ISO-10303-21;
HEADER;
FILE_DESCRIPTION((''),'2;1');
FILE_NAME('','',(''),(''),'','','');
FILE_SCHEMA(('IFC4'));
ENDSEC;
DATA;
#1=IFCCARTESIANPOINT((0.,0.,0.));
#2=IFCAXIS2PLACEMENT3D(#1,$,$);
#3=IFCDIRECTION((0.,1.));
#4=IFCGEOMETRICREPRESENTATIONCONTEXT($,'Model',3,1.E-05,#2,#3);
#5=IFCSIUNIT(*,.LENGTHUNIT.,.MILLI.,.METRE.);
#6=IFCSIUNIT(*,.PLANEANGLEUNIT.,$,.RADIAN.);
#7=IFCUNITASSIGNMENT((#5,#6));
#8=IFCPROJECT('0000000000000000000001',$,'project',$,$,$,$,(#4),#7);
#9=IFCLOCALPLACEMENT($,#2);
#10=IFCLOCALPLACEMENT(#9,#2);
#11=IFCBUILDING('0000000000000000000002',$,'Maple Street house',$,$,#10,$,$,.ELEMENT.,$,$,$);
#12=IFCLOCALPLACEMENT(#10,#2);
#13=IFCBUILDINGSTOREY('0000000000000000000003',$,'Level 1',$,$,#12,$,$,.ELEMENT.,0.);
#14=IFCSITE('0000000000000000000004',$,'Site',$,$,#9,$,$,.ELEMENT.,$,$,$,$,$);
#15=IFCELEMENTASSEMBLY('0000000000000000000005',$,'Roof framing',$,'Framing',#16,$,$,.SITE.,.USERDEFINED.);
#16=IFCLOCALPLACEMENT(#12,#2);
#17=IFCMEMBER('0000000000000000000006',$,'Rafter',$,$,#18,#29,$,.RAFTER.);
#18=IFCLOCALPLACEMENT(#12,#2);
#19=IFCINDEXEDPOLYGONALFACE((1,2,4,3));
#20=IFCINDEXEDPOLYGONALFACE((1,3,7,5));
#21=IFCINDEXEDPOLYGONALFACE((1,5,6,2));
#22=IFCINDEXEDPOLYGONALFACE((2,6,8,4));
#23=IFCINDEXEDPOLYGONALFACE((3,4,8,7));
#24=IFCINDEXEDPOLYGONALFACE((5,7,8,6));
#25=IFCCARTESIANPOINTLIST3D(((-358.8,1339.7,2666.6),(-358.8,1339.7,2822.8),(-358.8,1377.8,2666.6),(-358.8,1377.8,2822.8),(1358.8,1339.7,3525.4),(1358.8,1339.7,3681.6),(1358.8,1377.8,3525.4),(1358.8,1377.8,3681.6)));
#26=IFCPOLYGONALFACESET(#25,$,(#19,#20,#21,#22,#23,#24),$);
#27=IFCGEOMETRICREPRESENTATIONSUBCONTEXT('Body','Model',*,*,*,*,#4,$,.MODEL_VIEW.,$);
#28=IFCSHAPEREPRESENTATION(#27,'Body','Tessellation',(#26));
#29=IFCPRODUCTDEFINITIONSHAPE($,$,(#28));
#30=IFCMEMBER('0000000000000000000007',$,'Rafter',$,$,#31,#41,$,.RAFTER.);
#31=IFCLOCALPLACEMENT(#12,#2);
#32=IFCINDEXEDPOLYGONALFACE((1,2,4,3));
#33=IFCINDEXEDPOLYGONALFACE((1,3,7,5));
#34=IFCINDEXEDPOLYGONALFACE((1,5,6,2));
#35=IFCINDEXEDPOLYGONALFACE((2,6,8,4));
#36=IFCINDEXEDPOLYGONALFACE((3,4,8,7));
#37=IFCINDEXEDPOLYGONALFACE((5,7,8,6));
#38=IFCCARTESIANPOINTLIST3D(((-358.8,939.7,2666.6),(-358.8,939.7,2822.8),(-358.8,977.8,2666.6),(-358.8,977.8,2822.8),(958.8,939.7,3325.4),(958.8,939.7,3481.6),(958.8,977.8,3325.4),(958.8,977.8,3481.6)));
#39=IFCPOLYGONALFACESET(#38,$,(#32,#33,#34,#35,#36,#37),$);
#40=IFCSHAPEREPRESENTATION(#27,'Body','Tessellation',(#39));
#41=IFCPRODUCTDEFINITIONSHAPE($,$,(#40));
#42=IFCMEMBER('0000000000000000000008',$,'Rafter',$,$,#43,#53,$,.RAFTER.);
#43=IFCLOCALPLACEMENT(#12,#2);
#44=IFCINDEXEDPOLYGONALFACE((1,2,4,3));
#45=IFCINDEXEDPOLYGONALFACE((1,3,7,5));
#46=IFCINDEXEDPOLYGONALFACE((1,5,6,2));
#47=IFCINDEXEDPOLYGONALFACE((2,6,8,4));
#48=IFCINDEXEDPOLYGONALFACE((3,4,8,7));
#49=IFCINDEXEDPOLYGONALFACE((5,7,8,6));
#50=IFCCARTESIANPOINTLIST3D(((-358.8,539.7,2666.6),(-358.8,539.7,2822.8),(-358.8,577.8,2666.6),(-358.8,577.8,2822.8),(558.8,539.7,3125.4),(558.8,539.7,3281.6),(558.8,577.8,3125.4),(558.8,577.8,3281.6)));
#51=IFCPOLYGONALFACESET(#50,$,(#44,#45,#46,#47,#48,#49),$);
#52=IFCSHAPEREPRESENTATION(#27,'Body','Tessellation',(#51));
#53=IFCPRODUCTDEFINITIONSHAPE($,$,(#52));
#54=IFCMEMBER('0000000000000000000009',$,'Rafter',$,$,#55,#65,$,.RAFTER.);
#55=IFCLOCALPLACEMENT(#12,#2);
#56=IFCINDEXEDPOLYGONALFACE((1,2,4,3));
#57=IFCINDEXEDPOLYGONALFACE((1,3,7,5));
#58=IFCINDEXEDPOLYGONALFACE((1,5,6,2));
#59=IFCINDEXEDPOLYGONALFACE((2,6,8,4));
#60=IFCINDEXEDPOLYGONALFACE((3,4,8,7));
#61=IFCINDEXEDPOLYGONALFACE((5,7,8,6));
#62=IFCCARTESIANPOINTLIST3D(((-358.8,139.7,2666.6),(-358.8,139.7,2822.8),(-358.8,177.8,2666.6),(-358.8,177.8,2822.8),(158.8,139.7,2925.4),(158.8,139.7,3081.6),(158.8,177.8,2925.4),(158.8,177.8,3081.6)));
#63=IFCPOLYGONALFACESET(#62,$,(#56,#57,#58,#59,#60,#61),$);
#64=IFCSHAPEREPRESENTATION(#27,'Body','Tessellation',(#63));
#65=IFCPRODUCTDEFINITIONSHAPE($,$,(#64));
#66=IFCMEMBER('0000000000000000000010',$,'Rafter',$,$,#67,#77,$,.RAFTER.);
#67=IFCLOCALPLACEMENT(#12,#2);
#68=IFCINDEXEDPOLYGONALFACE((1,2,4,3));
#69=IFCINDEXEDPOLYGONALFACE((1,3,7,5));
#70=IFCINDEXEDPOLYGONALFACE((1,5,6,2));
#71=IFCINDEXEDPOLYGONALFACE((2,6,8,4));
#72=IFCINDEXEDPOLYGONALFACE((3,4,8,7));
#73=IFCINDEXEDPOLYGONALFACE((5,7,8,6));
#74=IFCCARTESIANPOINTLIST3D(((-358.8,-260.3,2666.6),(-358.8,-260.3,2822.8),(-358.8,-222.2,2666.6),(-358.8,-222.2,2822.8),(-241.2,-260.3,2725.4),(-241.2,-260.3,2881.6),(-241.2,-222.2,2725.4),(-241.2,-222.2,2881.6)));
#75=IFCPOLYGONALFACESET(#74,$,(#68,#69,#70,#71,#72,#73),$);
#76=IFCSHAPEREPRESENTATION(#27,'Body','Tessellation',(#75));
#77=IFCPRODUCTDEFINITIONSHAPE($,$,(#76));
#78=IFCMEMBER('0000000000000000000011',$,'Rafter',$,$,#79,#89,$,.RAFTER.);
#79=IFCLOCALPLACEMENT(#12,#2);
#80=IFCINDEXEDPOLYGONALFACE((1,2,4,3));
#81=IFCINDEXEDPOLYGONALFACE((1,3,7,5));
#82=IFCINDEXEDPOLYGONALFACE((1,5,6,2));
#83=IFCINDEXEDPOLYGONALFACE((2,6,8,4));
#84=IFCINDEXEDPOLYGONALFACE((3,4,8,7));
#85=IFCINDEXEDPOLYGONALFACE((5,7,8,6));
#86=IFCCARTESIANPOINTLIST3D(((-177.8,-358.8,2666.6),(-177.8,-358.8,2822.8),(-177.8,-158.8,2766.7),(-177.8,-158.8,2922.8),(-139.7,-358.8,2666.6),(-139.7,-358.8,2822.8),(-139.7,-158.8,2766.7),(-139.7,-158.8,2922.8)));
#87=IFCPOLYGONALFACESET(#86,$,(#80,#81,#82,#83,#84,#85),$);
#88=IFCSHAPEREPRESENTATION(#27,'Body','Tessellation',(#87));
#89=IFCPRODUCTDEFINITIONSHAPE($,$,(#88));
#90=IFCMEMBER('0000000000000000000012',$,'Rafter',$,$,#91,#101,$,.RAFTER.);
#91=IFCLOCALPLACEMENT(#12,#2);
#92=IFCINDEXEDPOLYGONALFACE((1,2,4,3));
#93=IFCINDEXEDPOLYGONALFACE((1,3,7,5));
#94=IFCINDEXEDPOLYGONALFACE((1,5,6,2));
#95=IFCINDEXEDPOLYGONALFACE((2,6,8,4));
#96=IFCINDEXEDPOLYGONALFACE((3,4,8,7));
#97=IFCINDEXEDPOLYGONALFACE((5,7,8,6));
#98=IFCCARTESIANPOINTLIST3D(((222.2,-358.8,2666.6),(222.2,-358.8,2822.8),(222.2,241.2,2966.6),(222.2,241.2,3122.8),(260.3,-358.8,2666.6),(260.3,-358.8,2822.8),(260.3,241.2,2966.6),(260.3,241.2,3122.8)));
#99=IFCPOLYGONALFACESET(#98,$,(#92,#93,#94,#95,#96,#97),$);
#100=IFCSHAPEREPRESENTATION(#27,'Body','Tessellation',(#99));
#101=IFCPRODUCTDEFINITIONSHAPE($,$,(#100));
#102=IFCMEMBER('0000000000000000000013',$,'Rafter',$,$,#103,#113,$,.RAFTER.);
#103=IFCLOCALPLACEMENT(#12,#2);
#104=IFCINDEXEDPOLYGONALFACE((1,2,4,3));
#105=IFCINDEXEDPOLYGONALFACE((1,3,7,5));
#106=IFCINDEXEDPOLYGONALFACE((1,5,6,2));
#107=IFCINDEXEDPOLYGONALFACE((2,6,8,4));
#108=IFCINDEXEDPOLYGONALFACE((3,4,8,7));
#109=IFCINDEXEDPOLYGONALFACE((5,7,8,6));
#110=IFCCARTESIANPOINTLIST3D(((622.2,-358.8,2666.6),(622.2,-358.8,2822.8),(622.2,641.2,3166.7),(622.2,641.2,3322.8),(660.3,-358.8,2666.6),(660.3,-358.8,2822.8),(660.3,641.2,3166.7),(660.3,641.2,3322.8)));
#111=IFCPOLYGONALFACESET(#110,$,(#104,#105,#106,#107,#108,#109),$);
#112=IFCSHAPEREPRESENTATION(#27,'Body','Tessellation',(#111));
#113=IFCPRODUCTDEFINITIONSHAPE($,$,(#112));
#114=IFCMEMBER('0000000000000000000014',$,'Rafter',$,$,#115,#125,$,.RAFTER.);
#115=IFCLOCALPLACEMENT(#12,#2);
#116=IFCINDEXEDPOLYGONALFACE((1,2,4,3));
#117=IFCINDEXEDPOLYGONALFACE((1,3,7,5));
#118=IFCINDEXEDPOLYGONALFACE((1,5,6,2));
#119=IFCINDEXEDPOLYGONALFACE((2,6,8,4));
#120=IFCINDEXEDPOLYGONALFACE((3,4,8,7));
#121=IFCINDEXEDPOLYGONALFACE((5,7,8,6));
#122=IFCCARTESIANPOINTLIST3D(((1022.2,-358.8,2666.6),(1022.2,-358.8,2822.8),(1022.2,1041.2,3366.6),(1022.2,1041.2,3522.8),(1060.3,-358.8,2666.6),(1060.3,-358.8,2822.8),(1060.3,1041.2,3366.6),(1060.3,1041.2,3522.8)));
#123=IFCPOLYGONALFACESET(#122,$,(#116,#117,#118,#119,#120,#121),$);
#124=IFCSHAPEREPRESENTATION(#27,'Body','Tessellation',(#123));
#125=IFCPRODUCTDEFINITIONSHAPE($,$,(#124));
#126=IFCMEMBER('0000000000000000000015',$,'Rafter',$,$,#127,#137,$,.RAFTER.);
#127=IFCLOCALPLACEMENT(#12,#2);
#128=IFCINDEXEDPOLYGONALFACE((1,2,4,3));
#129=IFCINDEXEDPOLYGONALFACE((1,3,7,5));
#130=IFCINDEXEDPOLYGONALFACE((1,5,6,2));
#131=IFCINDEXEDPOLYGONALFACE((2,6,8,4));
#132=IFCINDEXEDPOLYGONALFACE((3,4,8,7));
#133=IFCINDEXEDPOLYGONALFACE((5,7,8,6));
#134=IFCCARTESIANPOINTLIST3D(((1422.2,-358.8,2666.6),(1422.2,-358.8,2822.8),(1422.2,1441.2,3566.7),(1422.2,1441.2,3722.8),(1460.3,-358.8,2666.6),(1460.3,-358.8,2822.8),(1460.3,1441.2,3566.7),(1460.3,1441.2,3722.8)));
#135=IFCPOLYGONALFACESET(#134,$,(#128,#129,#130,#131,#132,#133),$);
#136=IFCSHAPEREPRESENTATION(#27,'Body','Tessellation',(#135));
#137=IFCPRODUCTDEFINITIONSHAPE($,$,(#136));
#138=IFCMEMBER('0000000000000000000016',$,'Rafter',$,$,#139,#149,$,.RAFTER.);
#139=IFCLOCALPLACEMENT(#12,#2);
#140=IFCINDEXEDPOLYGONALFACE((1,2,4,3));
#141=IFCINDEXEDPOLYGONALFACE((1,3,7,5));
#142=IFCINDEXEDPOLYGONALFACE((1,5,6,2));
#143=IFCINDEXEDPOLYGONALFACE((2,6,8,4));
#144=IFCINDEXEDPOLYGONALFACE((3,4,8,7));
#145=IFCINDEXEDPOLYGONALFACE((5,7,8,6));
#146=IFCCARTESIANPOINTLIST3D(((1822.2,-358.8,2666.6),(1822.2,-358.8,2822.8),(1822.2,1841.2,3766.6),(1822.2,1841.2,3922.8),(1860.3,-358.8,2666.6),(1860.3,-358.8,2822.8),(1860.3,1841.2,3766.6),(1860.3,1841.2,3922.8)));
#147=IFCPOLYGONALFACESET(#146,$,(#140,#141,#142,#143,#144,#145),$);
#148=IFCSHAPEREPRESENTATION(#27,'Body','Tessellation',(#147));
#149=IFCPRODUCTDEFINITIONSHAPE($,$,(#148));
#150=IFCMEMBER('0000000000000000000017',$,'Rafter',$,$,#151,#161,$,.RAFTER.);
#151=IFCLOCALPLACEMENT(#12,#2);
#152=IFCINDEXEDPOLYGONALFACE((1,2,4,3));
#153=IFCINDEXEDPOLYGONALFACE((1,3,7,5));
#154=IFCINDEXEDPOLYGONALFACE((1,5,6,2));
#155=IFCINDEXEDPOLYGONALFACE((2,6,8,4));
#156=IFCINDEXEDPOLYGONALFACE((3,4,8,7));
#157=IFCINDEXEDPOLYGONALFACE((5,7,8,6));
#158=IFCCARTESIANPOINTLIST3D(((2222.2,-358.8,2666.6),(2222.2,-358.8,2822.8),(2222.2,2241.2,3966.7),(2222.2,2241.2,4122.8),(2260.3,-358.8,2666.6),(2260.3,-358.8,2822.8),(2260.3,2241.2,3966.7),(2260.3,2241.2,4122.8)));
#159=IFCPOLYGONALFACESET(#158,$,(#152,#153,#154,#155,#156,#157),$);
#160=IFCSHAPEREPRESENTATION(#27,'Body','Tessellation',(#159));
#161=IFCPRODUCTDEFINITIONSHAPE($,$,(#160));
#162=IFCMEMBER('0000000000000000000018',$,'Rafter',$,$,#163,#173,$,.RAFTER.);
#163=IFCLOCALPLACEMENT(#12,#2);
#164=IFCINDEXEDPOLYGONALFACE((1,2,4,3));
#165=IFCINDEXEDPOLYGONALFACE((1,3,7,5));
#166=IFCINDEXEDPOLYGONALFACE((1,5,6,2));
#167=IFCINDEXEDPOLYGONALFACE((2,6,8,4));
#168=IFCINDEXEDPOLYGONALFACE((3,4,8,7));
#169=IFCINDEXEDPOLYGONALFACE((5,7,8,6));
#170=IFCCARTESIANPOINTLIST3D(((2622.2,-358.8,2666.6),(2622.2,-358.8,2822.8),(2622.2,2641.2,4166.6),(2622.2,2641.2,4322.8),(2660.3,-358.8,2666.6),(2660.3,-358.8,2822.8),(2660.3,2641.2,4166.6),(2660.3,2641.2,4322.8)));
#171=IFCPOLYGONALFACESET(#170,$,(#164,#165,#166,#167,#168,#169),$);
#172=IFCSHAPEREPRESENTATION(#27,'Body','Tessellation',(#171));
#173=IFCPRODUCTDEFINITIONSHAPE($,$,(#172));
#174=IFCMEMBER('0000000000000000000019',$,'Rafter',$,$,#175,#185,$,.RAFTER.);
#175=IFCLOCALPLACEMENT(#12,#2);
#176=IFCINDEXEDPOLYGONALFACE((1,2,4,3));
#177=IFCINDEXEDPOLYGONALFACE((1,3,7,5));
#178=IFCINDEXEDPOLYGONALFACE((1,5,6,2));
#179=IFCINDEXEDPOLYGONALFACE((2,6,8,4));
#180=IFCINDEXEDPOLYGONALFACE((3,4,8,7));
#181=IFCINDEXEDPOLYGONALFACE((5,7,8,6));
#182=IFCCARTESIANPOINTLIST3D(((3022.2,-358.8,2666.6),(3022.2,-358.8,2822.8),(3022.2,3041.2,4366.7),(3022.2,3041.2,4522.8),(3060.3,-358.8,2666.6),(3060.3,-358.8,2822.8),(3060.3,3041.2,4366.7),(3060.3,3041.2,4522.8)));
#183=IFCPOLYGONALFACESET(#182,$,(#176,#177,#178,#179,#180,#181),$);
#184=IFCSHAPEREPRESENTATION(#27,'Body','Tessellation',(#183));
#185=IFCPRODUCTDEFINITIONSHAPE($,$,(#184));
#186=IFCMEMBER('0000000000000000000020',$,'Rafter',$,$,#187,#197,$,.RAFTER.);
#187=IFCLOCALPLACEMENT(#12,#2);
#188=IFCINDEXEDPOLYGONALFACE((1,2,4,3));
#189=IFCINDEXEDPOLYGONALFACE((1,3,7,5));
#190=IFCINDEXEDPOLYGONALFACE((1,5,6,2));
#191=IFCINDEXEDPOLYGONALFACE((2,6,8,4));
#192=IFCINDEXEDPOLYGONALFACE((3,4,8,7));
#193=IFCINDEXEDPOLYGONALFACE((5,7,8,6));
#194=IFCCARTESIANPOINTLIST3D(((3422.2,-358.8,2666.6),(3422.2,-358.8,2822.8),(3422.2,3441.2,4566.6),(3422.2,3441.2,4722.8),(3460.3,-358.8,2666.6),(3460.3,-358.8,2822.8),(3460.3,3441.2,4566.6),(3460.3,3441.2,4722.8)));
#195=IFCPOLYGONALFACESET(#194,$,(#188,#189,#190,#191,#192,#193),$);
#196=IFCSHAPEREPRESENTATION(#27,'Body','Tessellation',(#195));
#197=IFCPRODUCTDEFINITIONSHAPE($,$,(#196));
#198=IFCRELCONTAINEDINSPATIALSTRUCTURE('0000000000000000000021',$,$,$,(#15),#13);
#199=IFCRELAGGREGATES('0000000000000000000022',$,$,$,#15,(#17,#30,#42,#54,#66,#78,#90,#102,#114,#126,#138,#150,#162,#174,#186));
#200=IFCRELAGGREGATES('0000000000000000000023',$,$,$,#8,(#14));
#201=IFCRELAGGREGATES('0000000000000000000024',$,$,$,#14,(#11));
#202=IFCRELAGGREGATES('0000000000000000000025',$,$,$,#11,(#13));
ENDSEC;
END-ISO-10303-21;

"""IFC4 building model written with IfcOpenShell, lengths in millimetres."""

from ifc_helpers import new_model, si_unit, direction, frame, origin, origin_with_axes, place, context, subcontext, project, spatial, polyline, outline, extrude, element, aggregate, save


model = new_model("IFC4")

# Units and contexts
model_context = context("Model", 3, precision=1e-05, world=origin(), true_north=direction((0.0, 1.0)))
body_context = subcontext(model_context, "Body", "Model", "MODEL_VIEW")
ifc_project = project(units=[si_unit("LENGTHUNIT", "METRE", prefix="MILLI"), si_unit("PLANEANGLEUNIT", "RADIAN")], contexts=[model_context])

# Site, building, storey
site_placement = place(None, origin())
site = spatial("IfcSite", under=ifc_project, at=site_placement, Name="Site", CompositionType="ELEMENT")
building_placement = place(site_placement, origin())
building = spatial("IfcBuilding", under=site, at=building_placement, Name="Maple Street house", CompositionType="ELEMENT")
storey_placement = place(building_placement, origin())
storey = spatial("IfcBuildingStorey", under=building, at=storey_placement, Name="Level 1", CompositionType="ELEMENT", Elevation=0.0)

# Element assembly, members
assembly_placement = place(storey_placement, origin_with_axes())
assembly = element("IfcElementAssembly", 1, at=assembly_placement, inside=storey, Name="Roof framing", ObjectType="Framing", AssemblyPlace="SITE", PredefinedType="USERDEFINED")
member_1_placement = place(storey_placement, origin_with_axes())
member_1 = element("IfcMember", 2, at=member_1_placement, Name="Rafter", PredefinedType="RAFTER", context=body_context, shape_type="SweptSolid", body=[
    extrude(outline(polyline([(0.0, 0.0), (38.1, 0.0), (38.1, 156.2), (0.0, 156.2), (0.0, 0.0)])), frame((-358.8, 1339.7, 2666.7), z_axis=(1.0, 0.0, 0.0), x_axis=(0.0, 1.0, 0.0)), (0.0, 0.447214, 0.894427), 1920.3),
])
member_2_placement = place(storey_placement, origin_with_axes())
member_2 = element("IfcMember", 3, at=member_2_placement, Name="Rafter", PredefinedType="RAFTER", context=body_context, shape_type="SweptSolid", body=[
    extrude(outline(polyline([(0.0, 0.0), (38.1, 0.0), (38.1, 156.2), (0.0, 156.2), (0.0, 0.0)])), frame((-358.8, 939.7, 2666.7), z_axis=(1.0, 0.0, 0.0), x_axis=(0.0, 1.0, 0.0)), (0.0, 0.447214, 0.894427), 1473.1),
])
member_3_placement = place(storey_placement, origin_with_axes())
member_3 = element("IfcMember", 4, at=member_3_placement, Name="Rafter", PredefinedType="RAFTER", context=body_context, shape_type="SweptSolid", body=[
    extrude(outline(polyline([(0.0, 0.0), (38.1, 0.0), (38.1, 156.2), (0.0, 156.2), (0.0, 0.0)])), frame((-358.8, 539.7, 2666.7), z_axis=(1.0, 0.0, 0.0), x_axis=(0.0, 1.0, 0.0)), (0.0, 0.447214, 0.894427), 1025.9),
])
member_4_placement = place(storey_placement, origin_with_axes())
member_4 = element("IfcMember", 5, at=member_4_placement, Name="Rafter", PredefinedType="RAFTER", context=body_context, shape_type="SweptSolid", body=[
    extrude(outline(polyline([(0.0, 0.0), (38.1, 0.0), (38.1, 156.2), (0.0, 156.2), (0.0, 0.0)])), frame((-358.8, 139.7, 2666.7), z_axis=(1.0, 0.0, 0.0), x_axis=(0.0, 1.0, 0.0)), (0.0, 0.447214, 0.894427), 578.6),
])
member_5_placement = place(storey_placement, origin_with_axes())
member_5 = element("IfcMember", 6, at=member_5_placement, Name="Rafter", PredefinedType="RAFTER", context=body_context, shape_type="SweptSolid", body=[
    extrude(outline(polyline([(0.0, 0.0), (38.1, 0.0), (38.1, 156.2), (0.0, 156.2), (0.0, 0.0)])), frame((-358.8, -260.3, 2666.7), z_axis=(1.0, 0.0, 0.0), x_axis=(0.0, 1.0, 0.0)), (0.0, 0.447214, 0.894427), 131.4),
])
member_6_placement = place(storey_placement, origin_with_axes())
member_6 = element("IfcMember", 7, at=member_6_placement, Name="Rafter", PredefinedType="RAFTER", context=body_context, shape_type="SweptSolid", body=[
    extrude(outline(polyline([(0.0, 0.0), (38.1, 0.0), (38.1, 156.2), (0.0, 156.2), (0.0, 0.0)])), frame((-139.7, -358.8, 2666.7), z_axis=(0.0, 1.0, 0.0), x_axis=(-1.0, 0.0, 0.0)), (0.0, 0.447214, 0.894427), 223.6),
])
member_7_placement = place(storey_placement, origin_with_axes())
member_7 = element("IfcMember", 8, at=member_7_placement, Name="Rafter", PredefinedType="RAFTER", context=body_context, shape_type="SweptSolid", body=[
    extrude(outline(polyline([(0.0, 0.0), (38.1, 0.0), (38.1, 156.2), (0.0, 156.2), (0.0, 0.0)])), frame((260.3, -358.8, 2666.7), z_axis=(0.0, 1.0, 0.0), x_axis=(-1.0, 0.0, 0.0)), (0.0, 0.447214, 0.894427), 670.8),
])
member_8_placement = place(storey_placement, origin_with_axes())
member_8 = element("IfcMember", 9, at=member_8_placement, Name="Rafter", PredefinedType="RAFTER", context=body_context, shape_type="SweptSolid", body=[
    extrude(outline(polyline([(0.0, 0.0), (38.1, 0.0), (38.1, 156.2), (0.0, 156.2), (0.0, 0.0)])), frame((660.3, -358.8, 2666.7), z_axis=(0.0, 1.0, 0.0), x_axis=(-1.0, 0.0, 0.0)), (0.0, 0.447214, 0.894427), 1118.0),
])
member_9_placement = place(storey_placement, origin_with_axes())
member_9 = element("IfcMember", 10, at=member_9_placement, Name="Rafter", PredefinedType="RAFTER", context=body_context, shape_type="SweptSolid", body=[
    extrude(outline(polyline([(0.0, 0.0), (38.1, 0.0), (38.1, 156.2), (0.0, 156.2), (0.0, 0.0)])), frame((1060.3, -358.8, 2666.7), z_axis=(0.0, 1.0, 0.0), x_axis=(-1.0, 0.0, 0.0)), (0.0, 0.447214, 0.894427), 1565.2),
])
member_10_placement = place(storey_placement, origin_with_axes())
member_10 = element("IfcMember", 11, at=member_10_placement, Name="Rafter", PredefinedType="RAFTER", context=body_context, shape_type="SweptSolid", body=[
    extrude(outline(polyline([(0.0, 0.0), (38.1, 0.0), (38.1, 156.2), (0.0, 156.2), (0.0, 0.0)])), frame((1460.3, -358.8, 2666.7), z_axis=(0.0, 1.0, 0.0), x_axis=(-1.0, 0.0, 0.0)), (0.0, 0.447214, 0.894427), 2012.5),
])
member_11_placement = place(storey_placement, origin_with_axes())
member_11 = element("IfcMember", 12, at=member_11_placement, Name="Rafter", PredefinedType="RAFTER", context=body_context, shape_type="SweptSolid", body=[
    extrude(outline(polyline([(0.0, 0.0), (38.1, 0.0), (38.1, 156.2), (0.0, 156.2), (0.0, 0.0)])), frame((1860.3, -358.8, 2666.7), z_axis=(0.0, 1.0, 0.0), x_axis=(-1.0, 0.0, 0.0)), (0.0, 0.447214, 0.894427), 2459.7),
])
member_12_placement = place(storey_placement, origin_with_axes())
member_12 = element("IfcMember", 13, at=member_12_placement, Name="Rafter", PredefinedType="RAFTER", context=body_context, shape_type="SweptSolid", body=[
    extrude(outline(polyline([(0.0, 0.0), (38.1, 0.0), (38.1, 156.2), (0.0, 156.2), (0.0, 0.0)])), frame((2260.3, -358.8, 2666.7), z_axis=(0.0, 1.0, 0.0), x_axis=(-1.0, 0.0, 0.0)), (0.0, 0.447214, 0.894427), 2906.9),
])
member_13_placement = place(storey_placement, origin_with_axes())
member_13 = element("IfcMember", 14, at=member_13_placement, Name="Rafter", PredefinedType="RAFTER", context=body_context, shape_type="SweptSolid", body=[
    extrude(outline(polyline([(0.0, 0.0), (38.1, 0.0), (38.1, 156.2), (0.0, 156.2), (0.0, 0.0)])), frame((2660.3, -358.8, 2666.7), z_axis=(0.0, 1.0, 0.0), x_axis=(-1.0, 0.0, 0.0)), (0.0, 0.447214, 0.894427), 3354.1),
])
member_14_placement = place(storey_placement, origin_with_axes())
member_14 = element("IfcMember", 15, at=member_14_placement, Name="Rafter", PredefinedType="RAFTER", context=body_context, shape_type="SweptSolid", body=[
    extrude(outline(polyline([(0.0, 0.0), (38.1, 0.0), (38.1, 156.2), (0.0, 156.2), (0.0, 0.0)])), frame((3060.3, -358.8, 2666.7), z_axis=(0.0, 1.0, 0.0), x_axis=(-1.0, 0.0, 0.0)), (0.0, 0.447214, 0.894427), 3801.3),
])
member_15_placement = place(storey_placement, origin_with_axes())
member_15 = element("IfcMember", 16, at=member_15_placement, Name="Rafter", PredefinedType="RAFTER", context=body_context, shape_type="SweptSolid", body=[
    extrude(outline(polyline([(0.0, 0.0), (38.1, 0.0), (38.1, 156.2), (0.0, 156.2), (0.0, 0.0)])), frame((3460.3, -358.8, 2666.7), z_axis=(0.0, 1.0, 0.0), x_axis=(-1.0, 0.0, 0.0)), (0.0, 0.447214, 0.894427), 4248.5),
])
aggregate(assembly, [member_1, member_2, member_3, member_4, member_5, member_6, member_7, member_8, member_9, member_10, member_11, member_12, member_13, member_14, member_15])

save(model, "model.ifc")
